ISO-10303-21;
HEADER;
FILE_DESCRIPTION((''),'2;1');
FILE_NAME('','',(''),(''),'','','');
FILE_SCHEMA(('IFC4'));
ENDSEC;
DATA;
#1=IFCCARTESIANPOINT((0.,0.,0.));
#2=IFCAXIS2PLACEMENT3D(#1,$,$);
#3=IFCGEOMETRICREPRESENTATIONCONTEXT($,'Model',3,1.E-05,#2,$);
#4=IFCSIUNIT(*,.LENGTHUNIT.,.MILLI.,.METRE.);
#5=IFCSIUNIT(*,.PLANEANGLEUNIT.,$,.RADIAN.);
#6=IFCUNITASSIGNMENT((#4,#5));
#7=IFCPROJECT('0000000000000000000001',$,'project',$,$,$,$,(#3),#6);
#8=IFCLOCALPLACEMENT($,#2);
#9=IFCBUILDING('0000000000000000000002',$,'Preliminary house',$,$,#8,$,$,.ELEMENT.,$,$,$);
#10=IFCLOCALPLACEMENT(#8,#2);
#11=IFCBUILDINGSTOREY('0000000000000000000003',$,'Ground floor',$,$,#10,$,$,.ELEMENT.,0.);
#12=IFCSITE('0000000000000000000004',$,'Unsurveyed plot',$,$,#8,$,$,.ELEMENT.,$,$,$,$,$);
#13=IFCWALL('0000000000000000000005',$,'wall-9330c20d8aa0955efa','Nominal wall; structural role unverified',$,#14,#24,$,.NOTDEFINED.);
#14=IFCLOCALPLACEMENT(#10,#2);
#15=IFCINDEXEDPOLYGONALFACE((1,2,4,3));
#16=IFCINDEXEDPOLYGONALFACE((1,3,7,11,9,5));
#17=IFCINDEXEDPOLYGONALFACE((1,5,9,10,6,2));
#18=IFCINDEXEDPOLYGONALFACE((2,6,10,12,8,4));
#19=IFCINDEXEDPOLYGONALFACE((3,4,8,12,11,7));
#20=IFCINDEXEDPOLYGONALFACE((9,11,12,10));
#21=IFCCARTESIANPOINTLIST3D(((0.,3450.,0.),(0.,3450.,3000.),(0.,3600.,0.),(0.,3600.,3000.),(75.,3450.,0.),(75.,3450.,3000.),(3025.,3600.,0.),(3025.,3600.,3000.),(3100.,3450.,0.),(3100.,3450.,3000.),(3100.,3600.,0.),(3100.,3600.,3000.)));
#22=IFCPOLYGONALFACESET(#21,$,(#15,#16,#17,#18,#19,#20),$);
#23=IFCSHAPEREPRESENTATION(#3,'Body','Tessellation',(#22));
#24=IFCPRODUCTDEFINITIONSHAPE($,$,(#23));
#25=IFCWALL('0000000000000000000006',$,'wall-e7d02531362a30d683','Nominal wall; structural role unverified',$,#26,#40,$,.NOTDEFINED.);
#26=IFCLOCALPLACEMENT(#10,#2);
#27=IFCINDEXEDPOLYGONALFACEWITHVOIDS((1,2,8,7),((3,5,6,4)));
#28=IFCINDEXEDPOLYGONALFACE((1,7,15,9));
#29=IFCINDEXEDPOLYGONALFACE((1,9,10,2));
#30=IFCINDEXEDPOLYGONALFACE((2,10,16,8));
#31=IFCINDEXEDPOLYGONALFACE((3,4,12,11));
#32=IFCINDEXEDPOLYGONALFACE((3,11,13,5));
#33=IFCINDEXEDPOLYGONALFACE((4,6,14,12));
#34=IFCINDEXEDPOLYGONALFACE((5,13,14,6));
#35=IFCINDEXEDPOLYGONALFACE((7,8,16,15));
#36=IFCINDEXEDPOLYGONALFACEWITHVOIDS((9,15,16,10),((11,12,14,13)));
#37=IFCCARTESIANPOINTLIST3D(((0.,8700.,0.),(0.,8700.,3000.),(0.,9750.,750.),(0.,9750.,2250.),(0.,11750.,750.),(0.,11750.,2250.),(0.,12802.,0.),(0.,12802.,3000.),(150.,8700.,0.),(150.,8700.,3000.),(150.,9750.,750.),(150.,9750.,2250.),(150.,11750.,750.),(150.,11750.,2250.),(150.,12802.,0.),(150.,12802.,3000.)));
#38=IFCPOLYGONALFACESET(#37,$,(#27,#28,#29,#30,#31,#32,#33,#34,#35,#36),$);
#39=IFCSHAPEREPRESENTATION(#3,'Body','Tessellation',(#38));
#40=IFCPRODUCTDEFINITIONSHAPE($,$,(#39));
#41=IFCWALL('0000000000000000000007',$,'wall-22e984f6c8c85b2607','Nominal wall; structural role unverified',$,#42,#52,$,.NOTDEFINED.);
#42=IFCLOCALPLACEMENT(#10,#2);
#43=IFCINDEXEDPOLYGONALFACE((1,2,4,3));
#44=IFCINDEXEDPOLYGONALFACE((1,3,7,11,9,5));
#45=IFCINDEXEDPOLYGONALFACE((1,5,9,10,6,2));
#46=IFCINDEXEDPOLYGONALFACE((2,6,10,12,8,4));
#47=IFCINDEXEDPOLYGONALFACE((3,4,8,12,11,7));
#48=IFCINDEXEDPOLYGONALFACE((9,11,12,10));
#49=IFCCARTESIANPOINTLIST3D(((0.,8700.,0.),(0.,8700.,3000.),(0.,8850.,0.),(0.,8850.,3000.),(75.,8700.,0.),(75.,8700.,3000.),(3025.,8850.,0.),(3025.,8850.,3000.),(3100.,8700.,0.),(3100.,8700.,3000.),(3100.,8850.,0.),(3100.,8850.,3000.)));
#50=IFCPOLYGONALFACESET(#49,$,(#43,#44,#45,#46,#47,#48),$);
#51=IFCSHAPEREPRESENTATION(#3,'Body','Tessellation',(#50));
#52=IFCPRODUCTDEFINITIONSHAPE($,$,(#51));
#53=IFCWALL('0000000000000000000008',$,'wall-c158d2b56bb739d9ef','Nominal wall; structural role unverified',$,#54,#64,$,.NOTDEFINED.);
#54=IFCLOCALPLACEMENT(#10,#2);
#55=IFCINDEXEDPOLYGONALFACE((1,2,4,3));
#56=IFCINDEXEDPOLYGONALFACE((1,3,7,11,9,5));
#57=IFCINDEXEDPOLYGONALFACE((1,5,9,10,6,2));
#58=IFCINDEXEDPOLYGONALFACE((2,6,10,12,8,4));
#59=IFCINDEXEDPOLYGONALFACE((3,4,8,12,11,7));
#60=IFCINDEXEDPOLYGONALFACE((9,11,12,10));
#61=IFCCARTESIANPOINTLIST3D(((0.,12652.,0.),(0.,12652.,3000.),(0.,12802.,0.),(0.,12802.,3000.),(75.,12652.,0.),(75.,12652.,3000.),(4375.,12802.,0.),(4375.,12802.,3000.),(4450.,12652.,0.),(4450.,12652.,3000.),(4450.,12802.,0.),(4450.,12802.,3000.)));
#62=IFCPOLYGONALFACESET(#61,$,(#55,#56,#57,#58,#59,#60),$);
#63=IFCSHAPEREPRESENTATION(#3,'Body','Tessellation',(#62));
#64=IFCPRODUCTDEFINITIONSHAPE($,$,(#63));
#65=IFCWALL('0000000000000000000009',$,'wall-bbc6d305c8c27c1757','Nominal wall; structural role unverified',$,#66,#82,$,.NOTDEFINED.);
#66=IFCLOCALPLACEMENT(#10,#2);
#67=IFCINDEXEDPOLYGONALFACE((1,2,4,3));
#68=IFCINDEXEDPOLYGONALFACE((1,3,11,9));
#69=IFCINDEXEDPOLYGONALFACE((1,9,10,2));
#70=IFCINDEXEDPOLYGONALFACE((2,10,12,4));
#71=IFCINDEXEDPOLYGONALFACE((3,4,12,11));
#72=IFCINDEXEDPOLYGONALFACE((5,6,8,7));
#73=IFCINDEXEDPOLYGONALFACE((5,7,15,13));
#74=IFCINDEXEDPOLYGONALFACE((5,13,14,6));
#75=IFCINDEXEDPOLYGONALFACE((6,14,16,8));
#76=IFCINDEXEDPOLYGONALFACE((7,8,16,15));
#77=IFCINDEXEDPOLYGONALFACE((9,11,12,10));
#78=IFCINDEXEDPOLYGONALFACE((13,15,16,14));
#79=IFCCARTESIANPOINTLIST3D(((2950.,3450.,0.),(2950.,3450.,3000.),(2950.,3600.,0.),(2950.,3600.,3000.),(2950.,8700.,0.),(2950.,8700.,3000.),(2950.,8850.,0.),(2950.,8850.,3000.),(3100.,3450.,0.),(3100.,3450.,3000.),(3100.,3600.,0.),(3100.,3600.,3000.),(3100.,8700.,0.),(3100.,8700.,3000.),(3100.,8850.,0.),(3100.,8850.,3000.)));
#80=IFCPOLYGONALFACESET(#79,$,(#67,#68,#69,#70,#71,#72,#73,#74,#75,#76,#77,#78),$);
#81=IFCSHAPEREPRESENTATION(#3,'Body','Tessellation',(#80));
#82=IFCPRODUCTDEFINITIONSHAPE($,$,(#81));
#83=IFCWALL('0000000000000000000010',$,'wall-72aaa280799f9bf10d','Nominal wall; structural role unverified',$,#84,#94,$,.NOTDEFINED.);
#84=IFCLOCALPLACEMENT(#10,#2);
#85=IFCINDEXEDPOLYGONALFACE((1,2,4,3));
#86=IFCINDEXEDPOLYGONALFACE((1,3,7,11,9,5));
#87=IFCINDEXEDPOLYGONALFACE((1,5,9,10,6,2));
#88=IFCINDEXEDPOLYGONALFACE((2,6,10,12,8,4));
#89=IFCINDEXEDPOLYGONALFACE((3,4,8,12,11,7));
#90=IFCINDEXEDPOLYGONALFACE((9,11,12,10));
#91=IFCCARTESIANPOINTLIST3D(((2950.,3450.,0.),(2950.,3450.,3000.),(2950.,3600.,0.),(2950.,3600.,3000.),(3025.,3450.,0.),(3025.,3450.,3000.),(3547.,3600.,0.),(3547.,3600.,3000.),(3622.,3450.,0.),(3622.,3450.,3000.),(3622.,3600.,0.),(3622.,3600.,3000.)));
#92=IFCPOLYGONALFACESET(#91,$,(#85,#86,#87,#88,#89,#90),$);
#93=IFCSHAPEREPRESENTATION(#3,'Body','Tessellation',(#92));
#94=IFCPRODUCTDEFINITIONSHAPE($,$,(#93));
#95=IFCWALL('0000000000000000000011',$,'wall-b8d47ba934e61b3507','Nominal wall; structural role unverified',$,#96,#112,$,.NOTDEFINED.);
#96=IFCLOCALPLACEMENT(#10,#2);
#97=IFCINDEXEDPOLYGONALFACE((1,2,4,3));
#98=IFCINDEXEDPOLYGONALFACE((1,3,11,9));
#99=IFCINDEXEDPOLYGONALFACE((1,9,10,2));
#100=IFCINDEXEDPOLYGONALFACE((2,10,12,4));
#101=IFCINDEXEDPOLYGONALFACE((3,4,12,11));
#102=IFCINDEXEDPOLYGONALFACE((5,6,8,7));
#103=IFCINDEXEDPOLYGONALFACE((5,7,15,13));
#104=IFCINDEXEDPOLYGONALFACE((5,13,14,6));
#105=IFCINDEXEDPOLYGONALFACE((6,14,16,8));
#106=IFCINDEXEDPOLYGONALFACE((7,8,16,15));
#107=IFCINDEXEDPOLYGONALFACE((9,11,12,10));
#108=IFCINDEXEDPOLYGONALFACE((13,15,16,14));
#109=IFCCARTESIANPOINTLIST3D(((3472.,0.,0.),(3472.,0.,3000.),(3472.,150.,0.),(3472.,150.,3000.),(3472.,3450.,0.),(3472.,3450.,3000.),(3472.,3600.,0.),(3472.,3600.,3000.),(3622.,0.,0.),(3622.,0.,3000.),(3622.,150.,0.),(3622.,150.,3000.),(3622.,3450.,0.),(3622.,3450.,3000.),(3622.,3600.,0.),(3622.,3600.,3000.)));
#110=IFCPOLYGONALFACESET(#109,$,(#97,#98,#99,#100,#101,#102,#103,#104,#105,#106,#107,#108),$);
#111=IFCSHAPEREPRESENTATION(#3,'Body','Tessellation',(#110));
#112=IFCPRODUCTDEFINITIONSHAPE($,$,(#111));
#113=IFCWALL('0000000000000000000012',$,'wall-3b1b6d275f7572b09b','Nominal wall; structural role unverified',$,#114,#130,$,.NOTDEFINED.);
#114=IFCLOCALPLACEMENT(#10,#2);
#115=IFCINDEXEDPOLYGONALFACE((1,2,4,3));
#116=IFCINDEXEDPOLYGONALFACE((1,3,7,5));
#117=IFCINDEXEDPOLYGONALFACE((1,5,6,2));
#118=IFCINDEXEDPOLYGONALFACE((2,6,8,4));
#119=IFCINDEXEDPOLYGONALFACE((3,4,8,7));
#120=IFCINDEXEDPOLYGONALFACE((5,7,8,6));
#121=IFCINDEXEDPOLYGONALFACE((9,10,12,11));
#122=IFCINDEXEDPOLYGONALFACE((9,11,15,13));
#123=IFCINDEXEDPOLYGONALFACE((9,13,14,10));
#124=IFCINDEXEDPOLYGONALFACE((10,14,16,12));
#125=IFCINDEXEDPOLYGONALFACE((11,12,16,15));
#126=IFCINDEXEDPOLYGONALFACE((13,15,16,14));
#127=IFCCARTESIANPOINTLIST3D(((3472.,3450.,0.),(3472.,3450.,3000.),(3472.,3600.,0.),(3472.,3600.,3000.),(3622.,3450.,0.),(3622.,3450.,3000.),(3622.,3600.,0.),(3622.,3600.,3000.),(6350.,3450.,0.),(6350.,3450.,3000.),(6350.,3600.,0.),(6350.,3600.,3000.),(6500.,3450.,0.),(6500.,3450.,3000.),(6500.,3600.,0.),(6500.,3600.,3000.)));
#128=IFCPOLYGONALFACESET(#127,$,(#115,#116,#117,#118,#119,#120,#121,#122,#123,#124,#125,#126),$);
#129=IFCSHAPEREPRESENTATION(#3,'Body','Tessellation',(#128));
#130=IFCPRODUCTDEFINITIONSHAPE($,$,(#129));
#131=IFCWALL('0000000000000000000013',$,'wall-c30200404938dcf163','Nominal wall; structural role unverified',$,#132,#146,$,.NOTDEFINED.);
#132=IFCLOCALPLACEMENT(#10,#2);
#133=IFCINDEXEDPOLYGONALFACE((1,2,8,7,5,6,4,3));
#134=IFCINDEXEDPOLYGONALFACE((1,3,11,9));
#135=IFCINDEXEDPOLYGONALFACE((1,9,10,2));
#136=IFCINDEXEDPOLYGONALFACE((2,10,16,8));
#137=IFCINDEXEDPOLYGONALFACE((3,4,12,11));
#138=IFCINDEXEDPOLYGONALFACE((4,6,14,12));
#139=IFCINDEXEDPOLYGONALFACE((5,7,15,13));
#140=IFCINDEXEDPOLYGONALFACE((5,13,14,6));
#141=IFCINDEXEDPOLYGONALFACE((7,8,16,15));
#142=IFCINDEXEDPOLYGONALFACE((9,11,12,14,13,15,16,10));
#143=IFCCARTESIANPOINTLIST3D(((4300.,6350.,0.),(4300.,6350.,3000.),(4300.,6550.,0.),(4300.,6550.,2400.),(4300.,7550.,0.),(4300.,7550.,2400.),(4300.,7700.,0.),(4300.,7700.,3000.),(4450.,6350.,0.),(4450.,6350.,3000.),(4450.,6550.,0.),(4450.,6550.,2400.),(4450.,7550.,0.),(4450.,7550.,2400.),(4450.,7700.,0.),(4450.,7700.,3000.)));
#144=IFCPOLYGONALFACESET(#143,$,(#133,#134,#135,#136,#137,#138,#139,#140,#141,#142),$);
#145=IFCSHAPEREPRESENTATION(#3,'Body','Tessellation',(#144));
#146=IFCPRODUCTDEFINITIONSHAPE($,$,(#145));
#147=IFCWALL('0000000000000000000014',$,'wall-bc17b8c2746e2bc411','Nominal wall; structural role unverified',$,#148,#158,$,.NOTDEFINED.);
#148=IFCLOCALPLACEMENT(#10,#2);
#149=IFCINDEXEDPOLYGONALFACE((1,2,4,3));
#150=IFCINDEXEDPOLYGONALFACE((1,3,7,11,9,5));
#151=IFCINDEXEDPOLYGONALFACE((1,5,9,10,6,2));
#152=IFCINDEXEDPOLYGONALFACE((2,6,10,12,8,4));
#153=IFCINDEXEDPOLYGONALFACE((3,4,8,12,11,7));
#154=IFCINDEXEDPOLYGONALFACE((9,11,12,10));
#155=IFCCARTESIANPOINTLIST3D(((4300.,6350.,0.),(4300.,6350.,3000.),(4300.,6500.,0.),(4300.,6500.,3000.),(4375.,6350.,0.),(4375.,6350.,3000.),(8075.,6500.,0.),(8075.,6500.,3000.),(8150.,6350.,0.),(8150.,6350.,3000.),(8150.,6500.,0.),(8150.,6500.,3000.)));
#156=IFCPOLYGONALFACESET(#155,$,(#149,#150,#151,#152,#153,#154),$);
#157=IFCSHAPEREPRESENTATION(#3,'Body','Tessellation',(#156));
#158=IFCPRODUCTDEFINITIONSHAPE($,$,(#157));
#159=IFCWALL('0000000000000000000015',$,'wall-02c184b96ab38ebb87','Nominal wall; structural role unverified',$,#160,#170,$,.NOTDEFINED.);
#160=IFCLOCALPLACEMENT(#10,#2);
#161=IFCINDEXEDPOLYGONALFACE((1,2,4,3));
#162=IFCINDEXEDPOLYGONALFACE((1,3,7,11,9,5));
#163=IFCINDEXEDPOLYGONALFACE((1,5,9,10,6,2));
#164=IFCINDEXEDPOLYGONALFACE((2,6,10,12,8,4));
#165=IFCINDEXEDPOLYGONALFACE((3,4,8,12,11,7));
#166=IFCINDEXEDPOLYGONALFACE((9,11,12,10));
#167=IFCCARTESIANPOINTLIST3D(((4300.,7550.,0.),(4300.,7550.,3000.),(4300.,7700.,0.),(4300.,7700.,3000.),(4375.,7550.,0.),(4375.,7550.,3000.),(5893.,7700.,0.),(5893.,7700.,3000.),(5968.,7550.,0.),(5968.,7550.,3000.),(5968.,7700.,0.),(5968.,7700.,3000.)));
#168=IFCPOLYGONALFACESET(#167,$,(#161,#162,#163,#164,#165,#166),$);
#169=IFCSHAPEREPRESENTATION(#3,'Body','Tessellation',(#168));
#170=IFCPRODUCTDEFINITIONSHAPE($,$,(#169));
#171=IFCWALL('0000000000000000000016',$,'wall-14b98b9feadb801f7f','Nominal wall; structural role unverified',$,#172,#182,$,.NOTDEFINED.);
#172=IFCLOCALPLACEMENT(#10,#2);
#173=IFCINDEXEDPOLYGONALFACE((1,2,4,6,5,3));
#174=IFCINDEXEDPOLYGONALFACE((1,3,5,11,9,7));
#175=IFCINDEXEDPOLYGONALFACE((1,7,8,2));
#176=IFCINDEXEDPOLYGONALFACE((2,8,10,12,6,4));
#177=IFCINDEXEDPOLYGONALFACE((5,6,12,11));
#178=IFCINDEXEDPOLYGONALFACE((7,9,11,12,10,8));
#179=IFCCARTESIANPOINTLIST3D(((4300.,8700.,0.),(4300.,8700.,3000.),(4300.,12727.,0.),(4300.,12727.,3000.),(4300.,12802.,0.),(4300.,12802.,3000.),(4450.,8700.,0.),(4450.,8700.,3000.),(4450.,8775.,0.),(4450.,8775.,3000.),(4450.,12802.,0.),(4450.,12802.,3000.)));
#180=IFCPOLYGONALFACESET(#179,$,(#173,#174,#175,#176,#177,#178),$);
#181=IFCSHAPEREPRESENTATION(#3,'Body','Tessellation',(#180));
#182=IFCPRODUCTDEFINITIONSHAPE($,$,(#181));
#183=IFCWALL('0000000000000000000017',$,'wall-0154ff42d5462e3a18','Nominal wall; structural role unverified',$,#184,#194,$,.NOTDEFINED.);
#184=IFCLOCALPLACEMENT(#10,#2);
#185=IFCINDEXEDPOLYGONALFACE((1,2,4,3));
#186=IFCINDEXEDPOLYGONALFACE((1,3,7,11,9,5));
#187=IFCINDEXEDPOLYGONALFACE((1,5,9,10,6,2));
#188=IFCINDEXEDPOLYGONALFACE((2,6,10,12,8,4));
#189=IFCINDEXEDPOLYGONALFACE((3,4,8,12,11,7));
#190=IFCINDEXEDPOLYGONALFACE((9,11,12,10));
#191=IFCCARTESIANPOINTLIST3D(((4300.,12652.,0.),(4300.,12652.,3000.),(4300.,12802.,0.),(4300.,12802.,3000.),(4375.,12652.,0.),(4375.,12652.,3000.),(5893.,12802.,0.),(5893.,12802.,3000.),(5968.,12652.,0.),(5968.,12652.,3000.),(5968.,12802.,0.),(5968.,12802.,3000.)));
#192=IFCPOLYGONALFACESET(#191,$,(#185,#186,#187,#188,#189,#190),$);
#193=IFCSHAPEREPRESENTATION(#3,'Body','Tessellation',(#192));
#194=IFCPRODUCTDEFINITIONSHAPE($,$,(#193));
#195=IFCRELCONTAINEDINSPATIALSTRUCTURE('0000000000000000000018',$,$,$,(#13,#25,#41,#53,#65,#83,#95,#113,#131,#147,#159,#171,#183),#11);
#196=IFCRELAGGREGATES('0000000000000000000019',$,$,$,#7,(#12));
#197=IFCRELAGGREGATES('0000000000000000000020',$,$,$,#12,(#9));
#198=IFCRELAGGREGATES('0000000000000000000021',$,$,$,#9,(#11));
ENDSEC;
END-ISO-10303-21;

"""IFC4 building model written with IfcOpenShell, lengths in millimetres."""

from ifc_helpers import new_model, si_unit, frame, origin, place, context, project, spatial, polyline, outline, extrude, element, save


model = new_model("IFC4")

# Units and contexts
model_context = context("Model", 3, precision=1e-05, world=origin())
ifc_project = project(units=[si_unit("LENGTHUNIT", "METRE", prefix="MILLI"), si_unit("PLANEANGLEUNIT", "RADIAN")], contexts=[model_context])

# Site, building, storey
placement_1 = place(None, origin())
site = spatial("IfcSite", under=ifc_project, at=placement_1, Name="Unsurveyed plot", CompositionType="ELEMENT")
building = spatial("IfcBuilding", under=site, at=placement_1, Name="Preliminary house", CompositionType="ELEMENT")
placement_2 = place(placement_1, origin())
storey = spatial("IfcBuildingStorey", under=building, at=placement_2, Name="Ground floor", CompositionType="ELEMENT", Elevation=0.0)

# Wall
element("IfcWall", 1, at=placement_2, inside=storey, Name="wall-9330c20d8aa0955efa", Description="Nominal wall; structural role unverified", PredefinedType="NOTDEFINED", context=model_context, shape_type="SweptSolid", body=[
    extrude(outline(polyline([(3025.0, 3600.0), (3100.0, 3600.0), (3100.0, 3450.0), (75.0, 3450.0), (0.0, 3450.0), (0.0, 3600.0), (3025.0, 3600.0)])), origin(), (0.0, 0.0, 1.0), 3000.0),
])

# Wall, opening
wall_1 = element("IfcWall", 2, at=placement_2, inside=storey, Name="wall-e7d02531362a30d683", Description="Nominal wall; structural role unverified", PredefinedType="NOTDEFINED", context=model_context, shape_type="SweptSolid", body=[
    extrude(outline(polyline([(0.0, 12727.0), (0.0, 12802.0), (150.0, 12802.0), (150.0, 8775.0), (150.0, 8700.0), (0.0, 8700.0), (0.0, 12727.0)])), origin(), (0.0, 0.0, 1.0), 3000.0),
])
element("IfcOpeningElement", 3, at=placement_2, cuts=wall_1, PredefinedType="OPENING", context=model_context, shape_type="SweptSolid", body=[
    extrude(outline(polyline([(525.0, 9750.0), (525.0, 11750.0), (-375.0, 11750.0), (-375.0, 9750.0), (525.0, 9750.0)])), frame((0.0, 0.0, 750.0)), (0.0, 0.0, 1.0), 1500.0),
])

# Walls
element("IfcWall", 4, at=placement_2, inside=storey, Name="wall-22e984f6c8c85b2607", Description="Nominal wall; structural role unverified", PredefinedType="NOTDEFINED", context=model_context, shape_type="SweptSolid", body=[
    extrude(outline(polyline([(3025.0, 8850.0), (3100.0, 8850.0), (3100.0, 8700.0), (75.0, 8700.0), (0.0, 8700.0), (0.0, 8850.0), (3025.0, 8850.0)])), origin(), (0.0, 0.0, 1.0), 3000.0),
])
element("IfcWall", 5, at=placement_2, inside=storey, Name="wall-c158d2b56bb739d9ef", Description="Nominal wall; structural role unverified", PredefinedType="NOTDEFINED", context=model_context, shape_type="SweptSolid", body=[
    extrude(outline(polyline([(4375.0, 12802.0), (4450.0, 12802.0), (4450.0, 12652.0), (75.0, 12652.0), (0.0, 12652.0), (0.0, 12802.0), (4375.0, 12802.0)])), origin(), (0.0, 0.0, 1.0), 3000.0),
])

# Wall, opening
wall_2 = element("IfcWall", 6, at=placement_2, inside=storey, Name="wall-bbc6d305c8c27c1757", Description="Nominal wall; structural role unverified", PredefinedType="NOTDEFINED", context=model_context, shape_type="SweptSolid", body=[
    extrude(outline(polyline([(2950.0, 8775.0), (2950.0, 8850.0), (3100.0, 8850.0), (3100.0, 3525.0), (3100.0, 3450.0), (2950.0, 3450.0), (2950.0, 8775.0)])), origin(), (0.0, 0.0, 1.0), 3000.0),
])
element("IfcOpeningElement", 7, at=placement_2, cuts=wall_2, PredefinedType="OPENING", context=model_context, shape_type="SweptSolid", body=[
    extrude(outline(polyline([(3475.0, 3600.0), (3475.0, 8700.0), (2575.0, 8700.0), (2575.0, 3600.0), (3475.0, 3600.0)])), origin(), (0.0, 0.0, 1.0), 3000.0),
])

# Wall
element("IfcWall", 8, at=placement_2, inside=storey, Name="wall-72aaa280799f9bf10d", Description="Nominal wall; structural role unverified", PredefinedType="NOTDEFINED", context=model_context, shape_type="SweptSolid", body=[
    extrude(outline(polyline([(3547.0, 3600.0), (3622.0, 3600.0), (3622.0, 3450.0), (3025.0, 3450.0), (2950.0, 3450.0), (2950.0, 3600.0), (3547.0, 3600.0)])), origin(), (0.0, 0.0, 1.0), 3000.0),
])

# Walls, openings
wall_3 = element("IfcWall", 9, at=placement_2, inside=storey, Name="wall-b8d47ba934e61b3507", Description="Nominal wall; structural role unverified", PredefinedType="NOTDEFINED", context=model_context, shape_type="SweptSolid", body=[
    extrude(outline(polyline([(3472.0, 3525.0), (3472.0, 3600.0), (3622.0, 3600.0), (3622.0, 75.0), (3622.0, 0.0), (3472.0, 0.0), (3472.0, 3525.0)])), origin(), (0.0, 0.0, 1.0), 3000.0),
])
element("IfcOpeningElement", 10, at=placement_2, cuts=wall_3, PredefinedType="OPENING", context=model_context, shape_type="SweptSolid", body=[
    extrude(outline(polyline([(3997.0, 150.0), (3997.0, 3450.0), (3097.0, 3450.0), (3097.0, 150.0), (3997.0, 150.0)])), origin(), (0.0, 0.0, 1.0), 3000.0),
])
wall_4 = element("IfcWall", 11, at=placement_2, inside=storey, Name="wall-3b1b6d275f7572b09b", Description="Nominal wall; structural role unverified", PredefinedType="NOTDEFINED", context=model_context, shape_type="SweptSolid", body=[
    extrude(outline(polyline([(6425.0, 3600.0), (6500.0, 3600.0), (6500.0, 3450.0), (3547.0, 3450.0), (3472.0, 3450.0), (3472.0, 3600.0), (6425.0, 3600.0)])), origin(), (0.0, 0.0, 1.0), 3000.0),
])
element("IfcOpeningElement", 12, at=placement_2, cuts=wall_4, PredefinedType="OPENING", context=model_context, shape_type="SweptSolid", body=[
    extrude(outline(polyline([(3622.0, 3075.0), (6350.0, 3075.0), (6350.0, 3975.0), (3622.0, 3975.0), (3622.0, 3075.0)])), origin(), (0.0, 0.0, 1.0), 3000.0),
])
wall_5 = element("IfcWall", 13, at=placement_2, inside=storey, Name="wall-c30200404938dcf163", Description="Nominal wall; structural role unverified", PredefinedType="NOTDEFINED", context=model_context, shape_type="SweptSolid", body=[
    extrude(outline(polyline([(4300.0, 7625.0), (4300.0, 7700.0), (4450.0, 7700.0), (4450.0, 6425.0), (4450.0, 6350.0), (4300.0, 6350.0), (4300.0, 7625.0)])), origin(), (0.0, 0.0, 1.0), 3000.0),
])
element("IfcOpeningElement", 14, at=placement_2, cuts=wall_5, PredefinedType="OPENING", context=model_context, shape_type="SweptSolid", body=[
    extrude(outline(polyline([(4825.0, 6550.0), (4825.0, 7550.0), (3925.0, 7550.0), (3925.0, 6550.0), (4825.0, 6550.0)])), origin(), (0.0, 0.0, 1.0), 2400.0),
])

# Walls
element("IfcWall", 15, at=placement_2, inside=storey, Name="wall-bc17b8c2746e2bc411", Description="Nominal wall; structural role unverified", PredefinedType="NOTDEFINED", context=model_context, shape_type="SweptSolid", body=[
    extrude(outline(polyline([(8075.0, 6500.0), (8150.0, 6500.0), (8150.0, 6350.0), (4375.0, 6350.0), (4300.0, 6350.0), (4300.0, 6500.0), (8075.0, 6500.0)])), origin(), (0.0, 0.0, 1.0), 3000.0),
])
element("IfcWall", 16, at=placement_2, inside=storey, Name="wall-02c184b96ab38ebb87", Description="Nominal wall; structural role unverified", PredefinedType="NOTDEFINED", context=model_context, shape_type="SweptSolid", body=[
    extrude(outline(polyline([(5893.0, 7700.0), (5968.0, 7700.0), (5968.0, 7550.0), (4375.0, 7550.0), (4300.0, 7550.0), (4300.0, 7700.0), (5893.0, 7700.0)])), origin(), (0.0, 0.0, 1.0), 3000.0),
])
element("IfcWall", 17, at=placement_2, inside=storey, Name="wall-14b98b9feadb801f7f", Description="Nominal wall; structural role unverified", PredefinedType="NOTDEFINED", context=model_context, shape_type="SweptSolid", body=[
    extrude(outline(polyline([(4300.0, 12727.0), (4300.0, 12802.0), (4450.0, 12802.0), (4450.0, 8775.0), (4450.0, 8700.0), (4300.0, 8700.0), (4300.0, 12727.0)])), origin(), (0.0, 0.0, 1.0), 3000.0),
])

# Wall
element("IfcWall", 18, at=placement_2, inside=storey, Name="wall-0154ff42d5462e3a18", Description="Nominal wall; structural role unverified", PredefinedType="NOTDEFINED", context=model_context, shape_type="SweptSolid", body=[
    extrude(outline(polyline([(5893.0, 12802.0), (5968.0, 12802.0), (5968.0, 12652.0), (4375.0, 12652.0), (4300.0, 12652.0), (4300.0, 12802.0), (5893.0, 12802.0)])), origin(), (0.0, 0.0, 1.0), 3000.0),
])

save(model, "model.ifc")
